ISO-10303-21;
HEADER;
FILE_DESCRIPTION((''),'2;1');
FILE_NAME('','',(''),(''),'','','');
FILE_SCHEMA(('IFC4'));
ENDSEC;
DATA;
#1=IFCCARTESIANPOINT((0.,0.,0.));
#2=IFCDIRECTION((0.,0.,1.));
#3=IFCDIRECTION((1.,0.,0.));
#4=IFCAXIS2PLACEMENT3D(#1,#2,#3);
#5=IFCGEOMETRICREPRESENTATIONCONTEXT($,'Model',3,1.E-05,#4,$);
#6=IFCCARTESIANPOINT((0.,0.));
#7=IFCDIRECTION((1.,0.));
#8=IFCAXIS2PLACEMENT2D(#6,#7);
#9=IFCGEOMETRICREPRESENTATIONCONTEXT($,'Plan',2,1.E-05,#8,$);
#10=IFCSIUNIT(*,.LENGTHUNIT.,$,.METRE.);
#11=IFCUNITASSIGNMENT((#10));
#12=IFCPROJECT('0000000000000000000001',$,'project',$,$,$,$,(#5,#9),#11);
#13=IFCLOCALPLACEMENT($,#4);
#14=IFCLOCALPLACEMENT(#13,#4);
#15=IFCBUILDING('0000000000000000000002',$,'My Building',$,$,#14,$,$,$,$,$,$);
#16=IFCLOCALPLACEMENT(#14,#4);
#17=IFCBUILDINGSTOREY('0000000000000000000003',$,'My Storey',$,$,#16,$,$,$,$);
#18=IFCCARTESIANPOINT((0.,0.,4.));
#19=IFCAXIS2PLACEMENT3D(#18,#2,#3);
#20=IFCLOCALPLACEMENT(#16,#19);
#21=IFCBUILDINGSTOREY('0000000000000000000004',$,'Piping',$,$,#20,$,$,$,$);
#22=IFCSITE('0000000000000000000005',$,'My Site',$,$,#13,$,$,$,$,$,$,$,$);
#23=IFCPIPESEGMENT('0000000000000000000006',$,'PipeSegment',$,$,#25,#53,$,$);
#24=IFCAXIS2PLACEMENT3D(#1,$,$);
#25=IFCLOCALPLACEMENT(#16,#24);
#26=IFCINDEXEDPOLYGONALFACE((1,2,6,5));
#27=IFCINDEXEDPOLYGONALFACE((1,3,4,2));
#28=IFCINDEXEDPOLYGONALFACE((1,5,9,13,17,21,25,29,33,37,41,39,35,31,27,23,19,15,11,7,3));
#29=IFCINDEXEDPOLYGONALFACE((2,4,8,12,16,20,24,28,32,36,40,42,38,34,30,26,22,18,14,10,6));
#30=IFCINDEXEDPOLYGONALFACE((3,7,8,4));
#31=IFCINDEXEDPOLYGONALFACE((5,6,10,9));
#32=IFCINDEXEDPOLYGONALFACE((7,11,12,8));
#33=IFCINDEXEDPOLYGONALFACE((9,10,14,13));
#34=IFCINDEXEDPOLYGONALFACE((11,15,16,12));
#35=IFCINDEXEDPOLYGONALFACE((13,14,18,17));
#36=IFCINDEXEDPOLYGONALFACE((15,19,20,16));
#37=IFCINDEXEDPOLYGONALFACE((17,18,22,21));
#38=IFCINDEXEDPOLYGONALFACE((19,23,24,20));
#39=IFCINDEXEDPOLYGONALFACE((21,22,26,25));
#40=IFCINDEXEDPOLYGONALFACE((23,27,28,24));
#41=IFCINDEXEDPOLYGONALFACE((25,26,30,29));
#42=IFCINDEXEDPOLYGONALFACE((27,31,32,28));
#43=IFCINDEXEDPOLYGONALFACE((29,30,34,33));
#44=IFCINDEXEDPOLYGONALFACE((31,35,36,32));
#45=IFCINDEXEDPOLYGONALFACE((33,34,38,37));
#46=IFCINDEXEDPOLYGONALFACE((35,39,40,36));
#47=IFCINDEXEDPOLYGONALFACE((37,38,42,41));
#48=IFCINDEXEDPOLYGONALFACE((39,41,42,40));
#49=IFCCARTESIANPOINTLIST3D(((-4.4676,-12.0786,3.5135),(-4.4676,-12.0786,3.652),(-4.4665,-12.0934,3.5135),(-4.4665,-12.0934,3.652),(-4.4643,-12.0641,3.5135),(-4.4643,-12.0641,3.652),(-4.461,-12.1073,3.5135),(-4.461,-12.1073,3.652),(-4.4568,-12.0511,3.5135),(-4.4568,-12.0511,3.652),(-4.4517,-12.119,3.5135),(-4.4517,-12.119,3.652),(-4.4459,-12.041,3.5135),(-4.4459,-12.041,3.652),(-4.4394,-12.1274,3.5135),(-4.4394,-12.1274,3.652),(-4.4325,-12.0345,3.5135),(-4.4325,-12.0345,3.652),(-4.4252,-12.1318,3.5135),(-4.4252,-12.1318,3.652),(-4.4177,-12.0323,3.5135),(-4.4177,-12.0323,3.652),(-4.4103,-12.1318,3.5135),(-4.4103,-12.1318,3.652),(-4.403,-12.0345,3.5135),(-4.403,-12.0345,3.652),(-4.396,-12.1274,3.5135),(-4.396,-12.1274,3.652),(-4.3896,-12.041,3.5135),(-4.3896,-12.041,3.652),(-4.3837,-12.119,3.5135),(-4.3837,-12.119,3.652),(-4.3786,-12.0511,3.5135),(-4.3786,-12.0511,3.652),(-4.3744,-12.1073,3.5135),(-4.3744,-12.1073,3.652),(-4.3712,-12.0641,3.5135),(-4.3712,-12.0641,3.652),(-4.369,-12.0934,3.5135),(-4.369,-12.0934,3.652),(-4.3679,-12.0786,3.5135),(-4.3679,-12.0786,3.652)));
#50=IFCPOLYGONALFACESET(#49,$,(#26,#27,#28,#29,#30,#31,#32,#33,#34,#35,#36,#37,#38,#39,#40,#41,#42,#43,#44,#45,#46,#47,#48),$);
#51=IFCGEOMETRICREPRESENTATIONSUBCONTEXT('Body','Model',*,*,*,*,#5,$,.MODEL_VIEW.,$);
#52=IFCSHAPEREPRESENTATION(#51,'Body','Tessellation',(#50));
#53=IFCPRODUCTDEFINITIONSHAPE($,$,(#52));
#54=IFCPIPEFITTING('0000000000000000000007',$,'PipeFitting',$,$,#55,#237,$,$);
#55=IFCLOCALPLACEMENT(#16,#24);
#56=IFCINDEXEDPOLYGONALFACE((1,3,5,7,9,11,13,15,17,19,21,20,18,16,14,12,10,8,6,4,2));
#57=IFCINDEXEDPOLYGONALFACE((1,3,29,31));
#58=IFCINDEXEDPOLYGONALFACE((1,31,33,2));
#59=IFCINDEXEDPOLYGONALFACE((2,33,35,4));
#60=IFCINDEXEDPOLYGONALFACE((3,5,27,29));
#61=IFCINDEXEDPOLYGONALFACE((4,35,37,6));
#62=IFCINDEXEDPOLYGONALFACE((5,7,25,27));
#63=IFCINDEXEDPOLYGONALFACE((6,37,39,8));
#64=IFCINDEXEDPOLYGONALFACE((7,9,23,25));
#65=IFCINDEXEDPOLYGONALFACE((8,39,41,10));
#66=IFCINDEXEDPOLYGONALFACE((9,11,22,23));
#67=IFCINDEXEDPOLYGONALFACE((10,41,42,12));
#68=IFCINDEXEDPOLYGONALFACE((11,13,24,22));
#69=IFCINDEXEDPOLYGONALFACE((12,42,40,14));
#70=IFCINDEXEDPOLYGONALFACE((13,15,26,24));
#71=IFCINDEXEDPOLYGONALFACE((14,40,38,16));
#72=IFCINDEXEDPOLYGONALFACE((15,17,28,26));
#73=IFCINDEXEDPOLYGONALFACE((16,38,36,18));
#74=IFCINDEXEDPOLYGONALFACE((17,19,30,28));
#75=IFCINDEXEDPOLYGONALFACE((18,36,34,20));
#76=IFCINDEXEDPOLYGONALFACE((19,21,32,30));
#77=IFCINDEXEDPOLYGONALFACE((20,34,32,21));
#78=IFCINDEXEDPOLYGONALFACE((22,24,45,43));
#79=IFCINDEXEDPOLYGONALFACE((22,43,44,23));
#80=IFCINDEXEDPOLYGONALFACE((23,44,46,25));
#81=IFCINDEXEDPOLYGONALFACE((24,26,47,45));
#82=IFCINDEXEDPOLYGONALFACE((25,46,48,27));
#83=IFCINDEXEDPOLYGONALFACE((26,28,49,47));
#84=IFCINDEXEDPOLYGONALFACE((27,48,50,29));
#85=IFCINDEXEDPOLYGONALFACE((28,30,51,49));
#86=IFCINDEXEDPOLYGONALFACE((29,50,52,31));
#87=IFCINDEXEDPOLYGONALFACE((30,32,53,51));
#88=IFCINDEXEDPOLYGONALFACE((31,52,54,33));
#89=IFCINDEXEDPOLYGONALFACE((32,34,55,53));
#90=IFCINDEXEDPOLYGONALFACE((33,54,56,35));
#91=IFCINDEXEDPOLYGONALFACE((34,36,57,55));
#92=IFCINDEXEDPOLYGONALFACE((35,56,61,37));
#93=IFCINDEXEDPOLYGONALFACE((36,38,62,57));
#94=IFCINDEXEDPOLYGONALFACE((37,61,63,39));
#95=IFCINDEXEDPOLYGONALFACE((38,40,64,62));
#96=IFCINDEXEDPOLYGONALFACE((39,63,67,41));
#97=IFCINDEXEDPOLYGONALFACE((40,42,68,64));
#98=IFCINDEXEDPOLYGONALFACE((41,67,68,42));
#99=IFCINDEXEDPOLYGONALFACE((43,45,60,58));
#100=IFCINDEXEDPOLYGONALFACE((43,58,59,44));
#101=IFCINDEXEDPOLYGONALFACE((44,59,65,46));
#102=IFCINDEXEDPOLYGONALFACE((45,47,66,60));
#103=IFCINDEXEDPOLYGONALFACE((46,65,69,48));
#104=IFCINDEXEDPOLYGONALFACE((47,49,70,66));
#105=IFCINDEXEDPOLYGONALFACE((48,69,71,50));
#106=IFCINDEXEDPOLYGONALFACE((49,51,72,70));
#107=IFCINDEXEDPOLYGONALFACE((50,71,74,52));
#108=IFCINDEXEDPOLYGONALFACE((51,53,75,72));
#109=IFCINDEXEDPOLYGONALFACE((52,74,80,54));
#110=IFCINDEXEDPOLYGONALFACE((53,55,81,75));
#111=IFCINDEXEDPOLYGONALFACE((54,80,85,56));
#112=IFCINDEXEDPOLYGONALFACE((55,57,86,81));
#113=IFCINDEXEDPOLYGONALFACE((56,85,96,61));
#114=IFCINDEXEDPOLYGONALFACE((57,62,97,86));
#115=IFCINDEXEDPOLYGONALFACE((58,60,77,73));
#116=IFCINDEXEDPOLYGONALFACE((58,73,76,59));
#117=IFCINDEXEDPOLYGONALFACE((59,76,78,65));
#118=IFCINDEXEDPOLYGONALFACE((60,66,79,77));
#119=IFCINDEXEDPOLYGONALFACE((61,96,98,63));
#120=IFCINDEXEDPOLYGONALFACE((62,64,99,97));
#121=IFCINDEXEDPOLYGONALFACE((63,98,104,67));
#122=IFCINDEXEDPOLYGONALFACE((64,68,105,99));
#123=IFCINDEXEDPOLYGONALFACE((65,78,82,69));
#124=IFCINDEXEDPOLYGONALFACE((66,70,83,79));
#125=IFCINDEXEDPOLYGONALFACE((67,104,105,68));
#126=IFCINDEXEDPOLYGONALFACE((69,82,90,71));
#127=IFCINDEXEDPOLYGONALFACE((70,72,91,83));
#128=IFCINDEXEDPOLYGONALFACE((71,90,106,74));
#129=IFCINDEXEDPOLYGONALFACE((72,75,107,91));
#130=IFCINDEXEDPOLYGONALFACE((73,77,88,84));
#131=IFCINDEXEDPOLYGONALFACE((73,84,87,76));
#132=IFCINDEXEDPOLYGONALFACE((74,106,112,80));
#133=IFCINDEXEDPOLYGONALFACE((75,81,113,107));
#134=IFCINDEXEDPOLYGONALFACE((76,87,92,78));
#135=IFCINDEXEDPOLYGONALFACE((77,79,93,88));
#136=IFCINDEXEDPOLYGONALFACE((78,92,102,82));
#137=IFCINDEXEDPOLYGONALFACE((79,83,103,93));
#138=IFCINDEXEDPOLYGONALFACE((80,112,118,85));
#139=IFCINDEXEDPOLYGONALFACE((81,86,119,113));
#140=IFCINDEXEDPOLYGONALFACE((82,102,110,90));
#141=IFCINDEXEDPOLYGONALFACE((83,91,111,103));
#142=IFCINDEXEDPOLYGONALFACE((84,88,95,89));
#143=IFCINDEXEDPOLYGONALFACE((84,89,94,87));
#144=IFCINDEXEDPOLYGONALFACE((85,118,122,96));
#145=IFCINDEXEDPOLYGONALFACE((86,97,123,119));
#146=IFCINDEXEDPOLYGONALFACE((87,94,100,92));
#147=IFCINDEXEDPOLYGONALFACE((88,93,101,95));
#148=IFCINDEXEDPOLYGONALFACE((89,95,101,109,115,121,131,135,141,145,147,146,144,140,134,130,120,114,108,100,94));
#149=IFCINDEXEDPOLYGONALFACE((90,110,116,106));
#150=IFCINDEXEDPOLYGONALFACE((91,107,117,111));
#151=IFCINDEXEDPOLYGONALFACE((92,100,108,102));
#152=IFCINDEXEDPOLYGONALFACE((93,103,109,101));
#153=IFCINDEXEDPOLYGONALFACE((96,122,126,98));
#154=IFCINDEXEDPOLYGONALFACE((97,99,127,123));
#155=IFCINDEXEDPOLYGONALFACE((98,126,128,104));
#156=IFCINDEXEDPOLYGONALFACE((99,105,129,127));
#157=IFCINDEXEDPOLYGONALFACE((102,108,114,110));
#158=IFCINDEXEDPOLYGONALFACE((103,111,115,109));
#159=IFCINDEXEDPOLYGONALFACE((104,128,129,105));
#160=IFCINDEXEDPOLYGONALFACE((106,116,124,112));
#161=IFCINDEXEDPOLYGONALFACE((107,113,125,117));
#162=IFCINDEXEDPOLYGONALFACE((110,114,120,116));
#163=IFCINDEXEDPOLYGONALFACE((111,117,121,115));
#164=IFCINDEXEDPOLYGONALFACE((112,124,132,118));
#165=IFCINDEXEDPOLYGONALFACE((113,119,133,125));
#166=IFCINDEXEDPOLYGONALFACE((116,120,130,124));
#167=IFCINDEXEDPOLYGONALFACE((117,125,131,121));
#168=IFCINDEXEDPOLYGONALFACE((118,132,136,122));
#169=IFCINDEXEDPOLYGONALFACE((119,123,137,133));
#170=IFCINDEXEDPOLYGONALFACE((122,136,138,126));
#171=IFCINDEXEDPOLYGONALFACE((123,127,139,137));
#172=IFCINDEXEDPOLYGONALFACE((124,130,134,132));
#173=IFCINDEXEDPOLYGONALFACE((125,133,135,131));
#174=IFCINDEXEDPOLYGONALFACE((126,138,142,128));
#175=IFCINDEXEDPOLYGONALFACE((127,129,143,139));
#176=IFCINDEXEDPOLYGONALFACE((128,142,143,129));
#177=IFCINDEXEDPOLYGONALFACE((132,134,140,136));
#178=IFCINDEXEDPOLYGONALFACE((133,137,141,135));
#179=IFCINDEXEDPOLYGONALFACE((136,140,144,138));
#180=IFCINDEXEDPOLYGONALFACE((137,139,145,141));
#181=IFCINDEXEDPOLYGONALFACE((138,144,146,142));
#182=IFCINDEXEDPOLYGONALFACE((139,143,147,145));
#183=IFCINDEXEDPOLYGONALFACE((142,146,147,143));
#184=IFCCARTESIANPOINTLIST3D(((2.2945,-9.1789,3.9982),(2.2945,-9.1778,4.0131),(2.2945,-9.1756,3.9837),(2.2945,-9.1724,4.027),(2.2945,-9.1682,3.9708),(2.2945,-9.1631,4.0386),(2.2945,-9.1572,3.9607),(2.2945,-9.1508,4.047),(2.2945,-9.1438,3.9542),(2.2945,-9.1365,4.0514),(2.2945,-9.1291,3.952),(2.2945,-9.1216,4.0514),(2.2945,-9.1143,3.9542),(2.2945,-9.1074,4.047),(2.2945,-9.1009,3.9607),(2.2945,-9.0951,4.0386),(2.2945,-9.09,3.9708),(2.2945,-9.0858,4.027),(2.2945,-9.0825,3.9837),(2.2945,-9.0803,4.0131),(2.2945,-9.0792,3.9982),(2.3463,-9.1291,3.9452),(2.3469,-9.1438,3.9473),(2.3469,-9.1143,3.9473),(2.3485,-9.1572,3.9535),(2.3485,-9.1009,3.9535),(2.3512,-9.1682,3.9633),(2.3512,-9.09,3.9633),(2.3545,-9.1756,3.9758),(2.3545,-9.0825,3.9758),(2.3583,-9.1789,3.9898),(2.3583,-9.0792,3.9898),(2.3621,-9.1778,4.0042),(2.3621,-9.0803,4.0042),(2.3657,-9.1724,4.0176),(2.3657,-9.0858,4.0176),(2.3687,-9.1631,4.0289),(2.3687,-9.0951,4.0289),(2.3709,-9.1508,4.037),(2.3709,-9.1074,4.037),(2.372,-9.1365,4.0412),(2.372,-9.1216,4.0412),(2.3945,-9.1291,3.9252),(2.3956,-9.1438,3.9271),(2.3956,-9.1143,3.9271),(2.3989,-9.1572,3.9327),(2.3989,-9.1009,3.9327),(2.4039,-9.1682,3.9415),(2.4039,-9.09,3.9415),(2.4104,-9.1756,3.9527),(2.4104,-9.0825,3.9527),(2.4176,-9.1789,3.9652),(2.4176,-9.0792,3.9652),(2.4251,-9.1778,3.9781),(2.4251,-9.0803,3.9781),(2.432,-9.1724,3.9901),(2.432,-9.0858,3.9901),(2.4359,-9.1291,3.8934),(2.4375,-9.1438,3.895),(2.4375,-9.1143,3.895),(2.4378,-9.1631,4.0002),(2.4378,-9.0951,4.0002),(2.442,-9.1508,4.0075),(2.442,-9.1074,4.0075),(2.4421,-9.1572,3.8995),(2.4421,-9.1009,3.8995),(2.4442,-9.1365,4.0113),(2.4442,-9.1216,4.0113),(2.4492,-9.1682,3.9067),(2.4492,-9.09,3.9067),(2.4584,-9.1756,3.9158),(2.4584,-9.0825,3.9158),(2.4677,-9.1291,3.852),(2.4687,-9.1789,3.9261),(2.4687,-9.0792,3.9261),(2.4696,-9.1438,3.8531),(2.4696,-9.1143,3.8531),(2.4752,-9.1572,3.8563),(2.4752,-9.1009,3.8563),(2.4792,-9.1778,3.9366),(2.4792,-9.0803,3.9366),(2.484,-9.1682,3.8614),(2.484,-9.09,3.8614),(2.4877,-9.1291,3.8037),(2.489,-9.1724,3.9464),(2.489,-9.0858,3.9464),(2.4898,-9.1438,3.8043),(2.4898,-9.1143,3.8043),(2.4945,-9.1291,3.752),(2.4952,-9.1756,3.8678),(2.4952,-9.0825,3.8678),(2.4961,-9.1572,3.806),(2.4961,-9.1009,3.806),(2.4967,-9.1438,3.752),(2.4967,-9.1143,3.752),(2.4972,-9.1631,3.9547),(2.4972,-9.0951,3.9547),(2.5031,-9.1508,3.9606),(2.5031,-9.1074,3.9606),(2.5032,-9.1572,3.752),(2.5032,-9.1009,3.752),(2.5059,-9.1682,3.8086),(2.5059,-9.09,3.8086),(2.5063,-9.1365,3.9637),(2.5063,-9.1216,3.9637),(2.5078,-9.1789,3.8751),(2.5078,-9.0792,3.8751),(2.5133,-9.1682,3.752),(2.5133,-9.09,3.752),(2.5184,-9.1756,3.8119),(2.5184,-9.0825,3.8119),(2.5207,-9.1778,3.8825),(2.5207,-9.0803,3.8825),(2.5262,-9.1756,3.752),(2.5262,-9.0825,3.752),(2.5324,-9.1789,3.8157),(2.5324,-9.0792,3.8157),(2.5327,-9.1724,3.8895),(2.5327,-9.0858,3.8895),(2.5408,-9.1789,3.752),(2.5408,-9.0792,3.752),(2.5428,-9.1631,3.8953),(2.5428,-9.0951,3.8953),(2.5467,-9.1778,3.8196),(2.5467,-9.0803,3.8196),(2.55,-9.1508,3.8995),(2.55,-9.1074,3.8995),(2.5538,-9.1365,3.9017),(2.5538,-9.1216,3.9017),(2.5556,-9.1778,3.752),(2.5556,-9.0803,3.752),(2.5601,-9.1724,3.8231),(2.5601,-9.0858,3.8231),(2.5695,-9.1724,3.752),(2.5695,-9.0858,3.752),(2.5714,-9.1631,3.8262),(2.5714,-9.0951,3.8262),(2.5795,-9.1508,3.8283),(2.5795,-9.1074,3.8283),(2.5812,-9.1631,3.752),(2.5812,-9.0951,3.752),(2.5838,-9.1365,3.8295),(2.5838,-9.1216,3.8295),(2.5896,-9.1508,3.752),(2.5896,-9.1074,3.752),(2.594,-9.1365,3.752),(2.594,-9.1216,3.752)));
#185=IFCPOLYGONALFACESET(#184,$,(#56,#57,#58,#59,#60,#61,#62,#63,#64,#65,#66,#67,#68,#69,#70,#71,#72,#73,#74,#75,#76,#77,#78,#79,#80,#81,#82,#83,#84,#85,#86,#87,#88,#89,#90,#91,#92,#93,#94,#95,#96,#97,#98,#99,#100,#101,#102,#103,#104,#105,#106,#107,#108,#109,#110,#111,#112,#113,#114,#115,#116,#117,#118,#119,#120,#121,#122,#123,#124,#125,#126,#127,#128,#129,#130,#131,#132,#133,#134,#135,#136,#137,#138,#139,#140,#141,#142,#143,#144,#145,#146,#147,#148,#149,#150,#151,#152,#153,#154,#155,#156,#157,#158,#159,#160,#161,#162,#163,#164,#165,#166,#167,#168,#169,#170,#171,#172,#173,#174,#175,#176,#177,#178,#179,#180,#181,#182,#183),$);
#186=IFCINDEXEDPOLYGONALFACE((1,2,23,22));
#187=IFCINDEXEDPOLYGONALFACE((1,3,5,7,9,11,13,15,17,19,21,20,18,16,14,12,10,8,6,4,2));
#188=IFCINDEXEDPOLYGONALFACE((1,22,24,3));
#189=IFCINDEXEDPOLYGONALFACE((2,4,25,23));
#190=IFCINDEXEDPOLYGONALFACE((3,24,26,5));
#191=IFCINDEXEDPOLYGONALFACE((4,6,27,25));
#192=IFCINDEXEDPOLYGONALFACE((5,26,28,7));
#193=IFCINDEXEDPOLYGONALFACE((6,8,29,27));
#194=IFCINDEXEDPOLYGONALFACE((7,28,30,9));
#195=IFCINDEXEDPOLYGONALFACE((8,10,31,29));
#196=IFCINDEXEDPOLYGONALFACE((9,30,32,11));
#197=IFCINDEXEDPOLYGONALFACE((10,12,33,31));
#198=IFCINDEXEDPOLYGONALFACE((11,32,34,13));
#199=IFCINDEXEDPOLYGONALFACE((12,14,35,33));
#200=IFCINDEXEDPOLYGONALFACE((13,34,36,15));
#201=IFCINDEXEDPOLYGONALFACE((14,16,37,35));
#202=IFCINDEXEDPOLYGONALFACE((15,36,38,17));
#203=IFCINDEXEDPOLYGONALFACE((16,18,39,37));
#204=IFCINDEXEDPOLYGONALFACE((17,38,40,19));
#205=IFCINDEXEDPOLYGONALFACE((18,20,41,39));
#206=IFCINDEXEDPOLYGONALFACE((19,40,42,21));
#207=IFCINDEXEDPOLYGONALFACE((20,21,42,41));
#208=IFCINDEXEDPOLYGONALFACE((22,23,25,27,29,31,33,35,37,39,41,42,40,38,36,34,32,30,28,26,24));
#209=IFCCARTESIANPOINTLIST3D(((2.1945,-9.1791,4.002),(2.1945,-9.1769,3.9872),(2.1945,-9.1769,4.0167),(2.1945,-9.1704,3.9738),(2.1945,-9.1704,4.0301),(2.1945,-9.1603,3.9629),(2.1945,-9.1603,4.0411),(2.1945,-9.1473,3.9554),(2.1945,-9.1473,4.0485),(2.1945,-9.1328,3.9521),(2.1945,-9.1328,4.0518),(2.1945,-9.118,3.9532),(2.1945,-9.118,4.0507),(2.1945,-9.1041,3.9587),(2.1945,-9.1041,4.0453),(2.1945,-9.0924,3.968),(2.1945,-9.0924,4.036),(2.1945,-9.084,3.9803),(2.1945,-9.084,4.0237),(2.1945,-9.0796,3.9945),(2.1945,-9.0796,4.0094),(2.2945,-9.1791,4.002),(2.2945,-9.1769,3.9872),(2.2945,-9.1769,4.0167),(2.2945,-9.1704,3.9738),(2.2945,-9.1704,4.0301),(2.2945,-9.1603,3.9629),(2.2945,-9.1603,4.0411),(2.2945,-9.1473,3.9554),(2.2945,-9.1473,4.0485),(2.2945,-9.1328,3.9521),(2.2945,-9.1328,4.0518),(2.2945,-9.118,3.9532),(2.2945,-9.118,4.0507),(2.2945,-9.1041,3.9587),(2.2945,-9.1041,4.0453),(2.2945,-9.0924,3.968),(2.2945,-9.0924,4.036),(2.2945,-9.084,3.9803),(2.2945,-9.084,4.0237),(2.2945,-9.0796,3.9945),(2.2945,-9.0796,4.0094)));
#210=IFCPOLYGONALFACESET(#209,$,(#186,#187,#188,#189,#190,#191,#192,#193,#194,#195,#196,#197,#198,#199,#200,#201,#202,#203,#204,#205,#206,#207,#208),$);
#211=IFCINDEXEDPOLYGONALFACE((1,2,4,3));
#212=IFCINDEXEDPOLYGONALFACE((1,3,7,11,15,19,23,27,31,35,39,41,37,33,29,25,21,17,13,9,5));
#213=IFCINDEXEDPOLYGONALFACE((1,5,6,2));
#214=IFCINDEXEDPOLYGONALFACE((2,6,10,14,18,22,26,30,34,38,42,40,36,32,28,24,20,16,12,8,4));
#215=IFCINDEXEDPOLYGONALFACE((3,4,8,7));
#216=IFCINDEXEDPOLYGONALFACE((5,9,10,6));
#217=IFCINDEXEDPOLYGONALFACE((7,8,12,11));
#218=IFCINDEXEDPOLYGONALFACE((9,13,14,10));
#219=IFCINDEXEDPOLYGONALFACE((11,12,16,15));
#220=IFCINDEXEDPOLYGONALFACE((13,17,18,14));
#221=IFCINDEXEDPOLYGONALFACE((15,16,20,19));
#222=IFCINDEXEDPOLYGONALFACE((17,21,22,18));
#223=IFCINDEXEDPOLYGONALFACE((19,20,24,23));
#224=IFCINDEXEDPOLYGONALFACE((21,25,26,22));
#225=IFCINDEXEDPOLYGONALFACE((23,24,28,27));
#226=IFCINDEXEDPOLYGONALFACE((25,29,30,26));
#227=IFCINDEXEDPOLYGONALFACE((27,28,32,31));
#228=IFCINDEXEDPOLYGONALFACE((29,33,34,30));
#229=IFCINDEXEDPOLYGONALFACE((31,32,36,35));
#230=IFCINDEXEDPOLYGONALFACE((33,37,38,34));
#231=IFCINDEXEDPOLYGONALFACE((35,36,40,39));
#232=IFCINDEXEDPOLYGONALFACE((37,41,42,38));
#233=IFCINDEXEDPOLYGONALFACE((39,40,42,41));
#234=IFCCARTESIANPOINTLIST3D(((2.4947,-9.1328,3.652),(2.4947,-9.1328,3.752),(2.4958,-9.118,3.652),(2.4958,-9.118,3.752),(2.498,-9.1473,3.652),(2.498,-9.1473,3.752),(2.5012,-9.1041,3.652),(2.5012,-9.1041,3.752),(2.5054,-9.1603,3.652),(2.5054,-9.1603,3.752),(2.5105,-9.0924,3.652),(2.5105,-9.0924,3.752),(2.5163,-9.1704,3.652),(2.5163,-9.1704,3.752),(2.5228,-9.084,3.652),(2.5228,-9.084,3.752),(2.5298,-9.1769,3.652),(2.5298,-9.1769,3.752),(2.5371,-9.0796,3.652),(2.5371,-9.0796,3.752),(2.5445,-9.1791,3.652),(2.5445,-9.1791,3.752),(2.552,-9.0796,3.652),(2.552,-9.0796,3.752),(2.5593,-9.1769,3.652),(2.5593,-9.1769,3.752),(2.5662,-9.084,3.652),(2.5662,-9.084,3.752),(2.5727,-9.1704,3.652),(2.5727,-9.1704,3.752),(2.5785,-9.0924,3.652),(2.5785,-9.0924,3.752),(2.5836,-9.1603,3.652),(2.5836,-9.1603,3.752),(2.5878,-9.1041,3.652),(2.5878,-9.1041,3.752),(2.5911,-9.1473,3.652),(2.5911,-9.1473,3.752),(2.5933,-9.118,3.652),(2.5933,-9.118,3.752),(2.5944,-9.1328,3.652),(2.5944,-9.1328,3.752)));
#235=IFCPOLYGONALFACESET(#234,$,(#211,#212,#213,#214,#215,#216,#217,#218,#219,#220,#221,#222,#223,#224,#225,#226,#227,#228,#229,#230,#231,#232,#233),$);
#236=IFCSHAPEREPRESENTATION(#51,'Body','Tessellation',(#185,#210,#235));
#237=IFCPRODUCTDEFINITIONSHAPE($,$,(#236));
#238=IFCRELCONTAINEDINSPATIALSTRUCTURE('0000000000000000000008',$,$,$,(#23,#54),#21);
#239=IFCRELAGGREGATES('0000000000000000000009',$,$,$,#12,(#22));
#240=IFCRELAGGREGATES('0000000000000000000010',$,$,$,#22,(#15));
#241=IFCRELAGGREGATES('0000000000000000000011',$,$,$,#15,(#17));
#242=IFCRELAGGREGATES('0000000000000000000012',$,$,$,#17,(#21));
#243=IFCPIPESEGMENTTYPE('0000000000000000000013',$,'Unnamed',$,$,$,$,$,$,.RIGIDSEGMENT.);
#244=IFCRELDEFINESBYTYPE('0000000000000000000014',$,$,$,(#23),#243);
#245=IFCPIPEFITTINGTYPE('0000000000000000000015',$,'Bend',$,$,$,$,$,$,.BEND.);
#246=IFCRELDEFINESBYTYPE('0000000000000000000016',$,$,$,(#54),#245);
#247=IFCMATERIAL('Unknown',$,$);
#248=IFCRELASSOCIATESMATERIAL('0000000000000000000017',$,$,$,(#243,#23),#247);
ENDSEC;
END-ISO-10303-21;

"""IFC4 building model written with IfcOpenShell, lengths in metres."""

from ifc_helpers import new_model, entity, si_unit, frame, origin_with_axes, origin_2d_with_axis, place, context, subcontext, project, spatial, circle, extrude, source, transform, mapped, material, material_profile, profile_set, profile_usage, type_object, type_shapes, element, save


model = new_model("IFC4")

# Units and contexts
model_context = context("Model", 3, precision=1e-05, world=origin_with_axes())
plan_context = context("Plan", 2, precision=1e-05, world=origin_2d_with_axis())
body_context = subcontext(model_context, "Body", "Model", "MODEL_VIEW")
ifc_project = project(units=[si_unit("LENGTHUNIT", "METRE")], contexts=[model_context, plan_context])

# Site, building, storeys
site_placement = place(None, origin_with_axes())
site = spatial("IfcSite", under=ifc_project, at=site_placement, Name="My Site")
building_placement = place(site_placement, origin_with_axes())
building = spatial("IfcBuilding", under=site, at=building_placement, Name="My Building")
storey_1_placement = place(building_placement, origin_with_axes())
storey_1 = spatial("IfcBuildingStorey", under=building, at=storey_1_placement, Name="My Storey")
storey_2_placement = place(storey_1_placement, frame((0.0, 0.0, 4.0), z_axis=(0.0, 0.0, 1.0), x_axis=(1.0, 0.0, 0.0)))
storey_2 = spatial("IfcBuildingStorey", under=storey_1, at=storey_2_placement, Name="Piping")

# Pipe segment
ifc_material = material(Name="Unknown")
ifc_material_profile_1 = material_profile(ifc_material, circle(Radius=0.05))
ifc_profile_set_1 = profile_set([ifc_material_profile_1])
pipe_segment_type = type_object("IfcPipeSegmentType", Name="Unnamed", PredefinedType="RIGIDSEGMENT", material=ifc_profile_set_1)
ifc_profile_usage_1 = profile_usage(ifc_profile_set_1, cardinal=5)
pipe_segment_1_placement = place(storey_2_placement, frame((-4.4177, -12.0823, -0.348), z_axis=(0.0, 0.0, -1.0), x_axis=(0.0, 1.0, 0.0)))
element("IfcPipeSegment", 1, at=pipe_segment_1_placement, inside=storey_2, type_object=pipe_segment_type, material=ifc_profile_usage_1, Name="PipeSegment", context=body_context, shape_type="SweptSolid", body=[
    extrude(circle(Radius=0.05), origin_with_axes(), (0.0, 0.0, 1.0), 0.1385),
])

# Pipe fitting
pipe_fitting_type_1 = type_object("IfcPipeFittingType", Name="Bend", PredefinedType="BEND")
shared_shape = source(origin_with_axes(), body_context, "Body", "SolidModel", [
    entity("IfcSweptDiskSolid", entity("IfcIndexedPolyCurve", entity("IfcCartesianPointList3D", [[0.0, 0.0, -0.1], [0.0, -0.0732, -0.2768], [0.0, -0.25, -0.35]]), [entity("IfcArcIndex", [1, 2, 3])]), 0.05),
    extrude(circle(Radius=0.05), origin_with_axes(), (0.0, 0.0, -1.0), 0.1),
    extrude(circle(Radius=0.05), frame((0.0, -0.25, -0.35), z_axis=(0.0, -1.0, 0.0), x_axis=(1.0, 0.0, 0.0)), (0.0, 0.0, 1.0), 0.1),
])
type_shapes(pipe_fitting_type_1, [shared_shape])
pipe_fitting_1_placement = place(storey_2_placement, frame((2.1945, -9.1291, 0.002), z_axis=(-1.0, 0.0, -0.000001), x_axis=(0.0, -1.0, 0.0)))
element("IfcPipeFitting", 2, at=pipe_fitting_1_placement, inside=storey_2, type_object=pipe_fitting_type_1, Name="PipeFitting", context=body_context, shape_type="MappedRepresentation", body=[
    mapped(shared_shape, transform((0.0, 0.0, 0.0), x_axis=(1.0, 0.0, 0.0), y_axis=(0.0, 1.0, 0.0), z_axis=(0.0, 0.0, 1.0), scale=1.0)),
])

save(model, "model.ifc")
